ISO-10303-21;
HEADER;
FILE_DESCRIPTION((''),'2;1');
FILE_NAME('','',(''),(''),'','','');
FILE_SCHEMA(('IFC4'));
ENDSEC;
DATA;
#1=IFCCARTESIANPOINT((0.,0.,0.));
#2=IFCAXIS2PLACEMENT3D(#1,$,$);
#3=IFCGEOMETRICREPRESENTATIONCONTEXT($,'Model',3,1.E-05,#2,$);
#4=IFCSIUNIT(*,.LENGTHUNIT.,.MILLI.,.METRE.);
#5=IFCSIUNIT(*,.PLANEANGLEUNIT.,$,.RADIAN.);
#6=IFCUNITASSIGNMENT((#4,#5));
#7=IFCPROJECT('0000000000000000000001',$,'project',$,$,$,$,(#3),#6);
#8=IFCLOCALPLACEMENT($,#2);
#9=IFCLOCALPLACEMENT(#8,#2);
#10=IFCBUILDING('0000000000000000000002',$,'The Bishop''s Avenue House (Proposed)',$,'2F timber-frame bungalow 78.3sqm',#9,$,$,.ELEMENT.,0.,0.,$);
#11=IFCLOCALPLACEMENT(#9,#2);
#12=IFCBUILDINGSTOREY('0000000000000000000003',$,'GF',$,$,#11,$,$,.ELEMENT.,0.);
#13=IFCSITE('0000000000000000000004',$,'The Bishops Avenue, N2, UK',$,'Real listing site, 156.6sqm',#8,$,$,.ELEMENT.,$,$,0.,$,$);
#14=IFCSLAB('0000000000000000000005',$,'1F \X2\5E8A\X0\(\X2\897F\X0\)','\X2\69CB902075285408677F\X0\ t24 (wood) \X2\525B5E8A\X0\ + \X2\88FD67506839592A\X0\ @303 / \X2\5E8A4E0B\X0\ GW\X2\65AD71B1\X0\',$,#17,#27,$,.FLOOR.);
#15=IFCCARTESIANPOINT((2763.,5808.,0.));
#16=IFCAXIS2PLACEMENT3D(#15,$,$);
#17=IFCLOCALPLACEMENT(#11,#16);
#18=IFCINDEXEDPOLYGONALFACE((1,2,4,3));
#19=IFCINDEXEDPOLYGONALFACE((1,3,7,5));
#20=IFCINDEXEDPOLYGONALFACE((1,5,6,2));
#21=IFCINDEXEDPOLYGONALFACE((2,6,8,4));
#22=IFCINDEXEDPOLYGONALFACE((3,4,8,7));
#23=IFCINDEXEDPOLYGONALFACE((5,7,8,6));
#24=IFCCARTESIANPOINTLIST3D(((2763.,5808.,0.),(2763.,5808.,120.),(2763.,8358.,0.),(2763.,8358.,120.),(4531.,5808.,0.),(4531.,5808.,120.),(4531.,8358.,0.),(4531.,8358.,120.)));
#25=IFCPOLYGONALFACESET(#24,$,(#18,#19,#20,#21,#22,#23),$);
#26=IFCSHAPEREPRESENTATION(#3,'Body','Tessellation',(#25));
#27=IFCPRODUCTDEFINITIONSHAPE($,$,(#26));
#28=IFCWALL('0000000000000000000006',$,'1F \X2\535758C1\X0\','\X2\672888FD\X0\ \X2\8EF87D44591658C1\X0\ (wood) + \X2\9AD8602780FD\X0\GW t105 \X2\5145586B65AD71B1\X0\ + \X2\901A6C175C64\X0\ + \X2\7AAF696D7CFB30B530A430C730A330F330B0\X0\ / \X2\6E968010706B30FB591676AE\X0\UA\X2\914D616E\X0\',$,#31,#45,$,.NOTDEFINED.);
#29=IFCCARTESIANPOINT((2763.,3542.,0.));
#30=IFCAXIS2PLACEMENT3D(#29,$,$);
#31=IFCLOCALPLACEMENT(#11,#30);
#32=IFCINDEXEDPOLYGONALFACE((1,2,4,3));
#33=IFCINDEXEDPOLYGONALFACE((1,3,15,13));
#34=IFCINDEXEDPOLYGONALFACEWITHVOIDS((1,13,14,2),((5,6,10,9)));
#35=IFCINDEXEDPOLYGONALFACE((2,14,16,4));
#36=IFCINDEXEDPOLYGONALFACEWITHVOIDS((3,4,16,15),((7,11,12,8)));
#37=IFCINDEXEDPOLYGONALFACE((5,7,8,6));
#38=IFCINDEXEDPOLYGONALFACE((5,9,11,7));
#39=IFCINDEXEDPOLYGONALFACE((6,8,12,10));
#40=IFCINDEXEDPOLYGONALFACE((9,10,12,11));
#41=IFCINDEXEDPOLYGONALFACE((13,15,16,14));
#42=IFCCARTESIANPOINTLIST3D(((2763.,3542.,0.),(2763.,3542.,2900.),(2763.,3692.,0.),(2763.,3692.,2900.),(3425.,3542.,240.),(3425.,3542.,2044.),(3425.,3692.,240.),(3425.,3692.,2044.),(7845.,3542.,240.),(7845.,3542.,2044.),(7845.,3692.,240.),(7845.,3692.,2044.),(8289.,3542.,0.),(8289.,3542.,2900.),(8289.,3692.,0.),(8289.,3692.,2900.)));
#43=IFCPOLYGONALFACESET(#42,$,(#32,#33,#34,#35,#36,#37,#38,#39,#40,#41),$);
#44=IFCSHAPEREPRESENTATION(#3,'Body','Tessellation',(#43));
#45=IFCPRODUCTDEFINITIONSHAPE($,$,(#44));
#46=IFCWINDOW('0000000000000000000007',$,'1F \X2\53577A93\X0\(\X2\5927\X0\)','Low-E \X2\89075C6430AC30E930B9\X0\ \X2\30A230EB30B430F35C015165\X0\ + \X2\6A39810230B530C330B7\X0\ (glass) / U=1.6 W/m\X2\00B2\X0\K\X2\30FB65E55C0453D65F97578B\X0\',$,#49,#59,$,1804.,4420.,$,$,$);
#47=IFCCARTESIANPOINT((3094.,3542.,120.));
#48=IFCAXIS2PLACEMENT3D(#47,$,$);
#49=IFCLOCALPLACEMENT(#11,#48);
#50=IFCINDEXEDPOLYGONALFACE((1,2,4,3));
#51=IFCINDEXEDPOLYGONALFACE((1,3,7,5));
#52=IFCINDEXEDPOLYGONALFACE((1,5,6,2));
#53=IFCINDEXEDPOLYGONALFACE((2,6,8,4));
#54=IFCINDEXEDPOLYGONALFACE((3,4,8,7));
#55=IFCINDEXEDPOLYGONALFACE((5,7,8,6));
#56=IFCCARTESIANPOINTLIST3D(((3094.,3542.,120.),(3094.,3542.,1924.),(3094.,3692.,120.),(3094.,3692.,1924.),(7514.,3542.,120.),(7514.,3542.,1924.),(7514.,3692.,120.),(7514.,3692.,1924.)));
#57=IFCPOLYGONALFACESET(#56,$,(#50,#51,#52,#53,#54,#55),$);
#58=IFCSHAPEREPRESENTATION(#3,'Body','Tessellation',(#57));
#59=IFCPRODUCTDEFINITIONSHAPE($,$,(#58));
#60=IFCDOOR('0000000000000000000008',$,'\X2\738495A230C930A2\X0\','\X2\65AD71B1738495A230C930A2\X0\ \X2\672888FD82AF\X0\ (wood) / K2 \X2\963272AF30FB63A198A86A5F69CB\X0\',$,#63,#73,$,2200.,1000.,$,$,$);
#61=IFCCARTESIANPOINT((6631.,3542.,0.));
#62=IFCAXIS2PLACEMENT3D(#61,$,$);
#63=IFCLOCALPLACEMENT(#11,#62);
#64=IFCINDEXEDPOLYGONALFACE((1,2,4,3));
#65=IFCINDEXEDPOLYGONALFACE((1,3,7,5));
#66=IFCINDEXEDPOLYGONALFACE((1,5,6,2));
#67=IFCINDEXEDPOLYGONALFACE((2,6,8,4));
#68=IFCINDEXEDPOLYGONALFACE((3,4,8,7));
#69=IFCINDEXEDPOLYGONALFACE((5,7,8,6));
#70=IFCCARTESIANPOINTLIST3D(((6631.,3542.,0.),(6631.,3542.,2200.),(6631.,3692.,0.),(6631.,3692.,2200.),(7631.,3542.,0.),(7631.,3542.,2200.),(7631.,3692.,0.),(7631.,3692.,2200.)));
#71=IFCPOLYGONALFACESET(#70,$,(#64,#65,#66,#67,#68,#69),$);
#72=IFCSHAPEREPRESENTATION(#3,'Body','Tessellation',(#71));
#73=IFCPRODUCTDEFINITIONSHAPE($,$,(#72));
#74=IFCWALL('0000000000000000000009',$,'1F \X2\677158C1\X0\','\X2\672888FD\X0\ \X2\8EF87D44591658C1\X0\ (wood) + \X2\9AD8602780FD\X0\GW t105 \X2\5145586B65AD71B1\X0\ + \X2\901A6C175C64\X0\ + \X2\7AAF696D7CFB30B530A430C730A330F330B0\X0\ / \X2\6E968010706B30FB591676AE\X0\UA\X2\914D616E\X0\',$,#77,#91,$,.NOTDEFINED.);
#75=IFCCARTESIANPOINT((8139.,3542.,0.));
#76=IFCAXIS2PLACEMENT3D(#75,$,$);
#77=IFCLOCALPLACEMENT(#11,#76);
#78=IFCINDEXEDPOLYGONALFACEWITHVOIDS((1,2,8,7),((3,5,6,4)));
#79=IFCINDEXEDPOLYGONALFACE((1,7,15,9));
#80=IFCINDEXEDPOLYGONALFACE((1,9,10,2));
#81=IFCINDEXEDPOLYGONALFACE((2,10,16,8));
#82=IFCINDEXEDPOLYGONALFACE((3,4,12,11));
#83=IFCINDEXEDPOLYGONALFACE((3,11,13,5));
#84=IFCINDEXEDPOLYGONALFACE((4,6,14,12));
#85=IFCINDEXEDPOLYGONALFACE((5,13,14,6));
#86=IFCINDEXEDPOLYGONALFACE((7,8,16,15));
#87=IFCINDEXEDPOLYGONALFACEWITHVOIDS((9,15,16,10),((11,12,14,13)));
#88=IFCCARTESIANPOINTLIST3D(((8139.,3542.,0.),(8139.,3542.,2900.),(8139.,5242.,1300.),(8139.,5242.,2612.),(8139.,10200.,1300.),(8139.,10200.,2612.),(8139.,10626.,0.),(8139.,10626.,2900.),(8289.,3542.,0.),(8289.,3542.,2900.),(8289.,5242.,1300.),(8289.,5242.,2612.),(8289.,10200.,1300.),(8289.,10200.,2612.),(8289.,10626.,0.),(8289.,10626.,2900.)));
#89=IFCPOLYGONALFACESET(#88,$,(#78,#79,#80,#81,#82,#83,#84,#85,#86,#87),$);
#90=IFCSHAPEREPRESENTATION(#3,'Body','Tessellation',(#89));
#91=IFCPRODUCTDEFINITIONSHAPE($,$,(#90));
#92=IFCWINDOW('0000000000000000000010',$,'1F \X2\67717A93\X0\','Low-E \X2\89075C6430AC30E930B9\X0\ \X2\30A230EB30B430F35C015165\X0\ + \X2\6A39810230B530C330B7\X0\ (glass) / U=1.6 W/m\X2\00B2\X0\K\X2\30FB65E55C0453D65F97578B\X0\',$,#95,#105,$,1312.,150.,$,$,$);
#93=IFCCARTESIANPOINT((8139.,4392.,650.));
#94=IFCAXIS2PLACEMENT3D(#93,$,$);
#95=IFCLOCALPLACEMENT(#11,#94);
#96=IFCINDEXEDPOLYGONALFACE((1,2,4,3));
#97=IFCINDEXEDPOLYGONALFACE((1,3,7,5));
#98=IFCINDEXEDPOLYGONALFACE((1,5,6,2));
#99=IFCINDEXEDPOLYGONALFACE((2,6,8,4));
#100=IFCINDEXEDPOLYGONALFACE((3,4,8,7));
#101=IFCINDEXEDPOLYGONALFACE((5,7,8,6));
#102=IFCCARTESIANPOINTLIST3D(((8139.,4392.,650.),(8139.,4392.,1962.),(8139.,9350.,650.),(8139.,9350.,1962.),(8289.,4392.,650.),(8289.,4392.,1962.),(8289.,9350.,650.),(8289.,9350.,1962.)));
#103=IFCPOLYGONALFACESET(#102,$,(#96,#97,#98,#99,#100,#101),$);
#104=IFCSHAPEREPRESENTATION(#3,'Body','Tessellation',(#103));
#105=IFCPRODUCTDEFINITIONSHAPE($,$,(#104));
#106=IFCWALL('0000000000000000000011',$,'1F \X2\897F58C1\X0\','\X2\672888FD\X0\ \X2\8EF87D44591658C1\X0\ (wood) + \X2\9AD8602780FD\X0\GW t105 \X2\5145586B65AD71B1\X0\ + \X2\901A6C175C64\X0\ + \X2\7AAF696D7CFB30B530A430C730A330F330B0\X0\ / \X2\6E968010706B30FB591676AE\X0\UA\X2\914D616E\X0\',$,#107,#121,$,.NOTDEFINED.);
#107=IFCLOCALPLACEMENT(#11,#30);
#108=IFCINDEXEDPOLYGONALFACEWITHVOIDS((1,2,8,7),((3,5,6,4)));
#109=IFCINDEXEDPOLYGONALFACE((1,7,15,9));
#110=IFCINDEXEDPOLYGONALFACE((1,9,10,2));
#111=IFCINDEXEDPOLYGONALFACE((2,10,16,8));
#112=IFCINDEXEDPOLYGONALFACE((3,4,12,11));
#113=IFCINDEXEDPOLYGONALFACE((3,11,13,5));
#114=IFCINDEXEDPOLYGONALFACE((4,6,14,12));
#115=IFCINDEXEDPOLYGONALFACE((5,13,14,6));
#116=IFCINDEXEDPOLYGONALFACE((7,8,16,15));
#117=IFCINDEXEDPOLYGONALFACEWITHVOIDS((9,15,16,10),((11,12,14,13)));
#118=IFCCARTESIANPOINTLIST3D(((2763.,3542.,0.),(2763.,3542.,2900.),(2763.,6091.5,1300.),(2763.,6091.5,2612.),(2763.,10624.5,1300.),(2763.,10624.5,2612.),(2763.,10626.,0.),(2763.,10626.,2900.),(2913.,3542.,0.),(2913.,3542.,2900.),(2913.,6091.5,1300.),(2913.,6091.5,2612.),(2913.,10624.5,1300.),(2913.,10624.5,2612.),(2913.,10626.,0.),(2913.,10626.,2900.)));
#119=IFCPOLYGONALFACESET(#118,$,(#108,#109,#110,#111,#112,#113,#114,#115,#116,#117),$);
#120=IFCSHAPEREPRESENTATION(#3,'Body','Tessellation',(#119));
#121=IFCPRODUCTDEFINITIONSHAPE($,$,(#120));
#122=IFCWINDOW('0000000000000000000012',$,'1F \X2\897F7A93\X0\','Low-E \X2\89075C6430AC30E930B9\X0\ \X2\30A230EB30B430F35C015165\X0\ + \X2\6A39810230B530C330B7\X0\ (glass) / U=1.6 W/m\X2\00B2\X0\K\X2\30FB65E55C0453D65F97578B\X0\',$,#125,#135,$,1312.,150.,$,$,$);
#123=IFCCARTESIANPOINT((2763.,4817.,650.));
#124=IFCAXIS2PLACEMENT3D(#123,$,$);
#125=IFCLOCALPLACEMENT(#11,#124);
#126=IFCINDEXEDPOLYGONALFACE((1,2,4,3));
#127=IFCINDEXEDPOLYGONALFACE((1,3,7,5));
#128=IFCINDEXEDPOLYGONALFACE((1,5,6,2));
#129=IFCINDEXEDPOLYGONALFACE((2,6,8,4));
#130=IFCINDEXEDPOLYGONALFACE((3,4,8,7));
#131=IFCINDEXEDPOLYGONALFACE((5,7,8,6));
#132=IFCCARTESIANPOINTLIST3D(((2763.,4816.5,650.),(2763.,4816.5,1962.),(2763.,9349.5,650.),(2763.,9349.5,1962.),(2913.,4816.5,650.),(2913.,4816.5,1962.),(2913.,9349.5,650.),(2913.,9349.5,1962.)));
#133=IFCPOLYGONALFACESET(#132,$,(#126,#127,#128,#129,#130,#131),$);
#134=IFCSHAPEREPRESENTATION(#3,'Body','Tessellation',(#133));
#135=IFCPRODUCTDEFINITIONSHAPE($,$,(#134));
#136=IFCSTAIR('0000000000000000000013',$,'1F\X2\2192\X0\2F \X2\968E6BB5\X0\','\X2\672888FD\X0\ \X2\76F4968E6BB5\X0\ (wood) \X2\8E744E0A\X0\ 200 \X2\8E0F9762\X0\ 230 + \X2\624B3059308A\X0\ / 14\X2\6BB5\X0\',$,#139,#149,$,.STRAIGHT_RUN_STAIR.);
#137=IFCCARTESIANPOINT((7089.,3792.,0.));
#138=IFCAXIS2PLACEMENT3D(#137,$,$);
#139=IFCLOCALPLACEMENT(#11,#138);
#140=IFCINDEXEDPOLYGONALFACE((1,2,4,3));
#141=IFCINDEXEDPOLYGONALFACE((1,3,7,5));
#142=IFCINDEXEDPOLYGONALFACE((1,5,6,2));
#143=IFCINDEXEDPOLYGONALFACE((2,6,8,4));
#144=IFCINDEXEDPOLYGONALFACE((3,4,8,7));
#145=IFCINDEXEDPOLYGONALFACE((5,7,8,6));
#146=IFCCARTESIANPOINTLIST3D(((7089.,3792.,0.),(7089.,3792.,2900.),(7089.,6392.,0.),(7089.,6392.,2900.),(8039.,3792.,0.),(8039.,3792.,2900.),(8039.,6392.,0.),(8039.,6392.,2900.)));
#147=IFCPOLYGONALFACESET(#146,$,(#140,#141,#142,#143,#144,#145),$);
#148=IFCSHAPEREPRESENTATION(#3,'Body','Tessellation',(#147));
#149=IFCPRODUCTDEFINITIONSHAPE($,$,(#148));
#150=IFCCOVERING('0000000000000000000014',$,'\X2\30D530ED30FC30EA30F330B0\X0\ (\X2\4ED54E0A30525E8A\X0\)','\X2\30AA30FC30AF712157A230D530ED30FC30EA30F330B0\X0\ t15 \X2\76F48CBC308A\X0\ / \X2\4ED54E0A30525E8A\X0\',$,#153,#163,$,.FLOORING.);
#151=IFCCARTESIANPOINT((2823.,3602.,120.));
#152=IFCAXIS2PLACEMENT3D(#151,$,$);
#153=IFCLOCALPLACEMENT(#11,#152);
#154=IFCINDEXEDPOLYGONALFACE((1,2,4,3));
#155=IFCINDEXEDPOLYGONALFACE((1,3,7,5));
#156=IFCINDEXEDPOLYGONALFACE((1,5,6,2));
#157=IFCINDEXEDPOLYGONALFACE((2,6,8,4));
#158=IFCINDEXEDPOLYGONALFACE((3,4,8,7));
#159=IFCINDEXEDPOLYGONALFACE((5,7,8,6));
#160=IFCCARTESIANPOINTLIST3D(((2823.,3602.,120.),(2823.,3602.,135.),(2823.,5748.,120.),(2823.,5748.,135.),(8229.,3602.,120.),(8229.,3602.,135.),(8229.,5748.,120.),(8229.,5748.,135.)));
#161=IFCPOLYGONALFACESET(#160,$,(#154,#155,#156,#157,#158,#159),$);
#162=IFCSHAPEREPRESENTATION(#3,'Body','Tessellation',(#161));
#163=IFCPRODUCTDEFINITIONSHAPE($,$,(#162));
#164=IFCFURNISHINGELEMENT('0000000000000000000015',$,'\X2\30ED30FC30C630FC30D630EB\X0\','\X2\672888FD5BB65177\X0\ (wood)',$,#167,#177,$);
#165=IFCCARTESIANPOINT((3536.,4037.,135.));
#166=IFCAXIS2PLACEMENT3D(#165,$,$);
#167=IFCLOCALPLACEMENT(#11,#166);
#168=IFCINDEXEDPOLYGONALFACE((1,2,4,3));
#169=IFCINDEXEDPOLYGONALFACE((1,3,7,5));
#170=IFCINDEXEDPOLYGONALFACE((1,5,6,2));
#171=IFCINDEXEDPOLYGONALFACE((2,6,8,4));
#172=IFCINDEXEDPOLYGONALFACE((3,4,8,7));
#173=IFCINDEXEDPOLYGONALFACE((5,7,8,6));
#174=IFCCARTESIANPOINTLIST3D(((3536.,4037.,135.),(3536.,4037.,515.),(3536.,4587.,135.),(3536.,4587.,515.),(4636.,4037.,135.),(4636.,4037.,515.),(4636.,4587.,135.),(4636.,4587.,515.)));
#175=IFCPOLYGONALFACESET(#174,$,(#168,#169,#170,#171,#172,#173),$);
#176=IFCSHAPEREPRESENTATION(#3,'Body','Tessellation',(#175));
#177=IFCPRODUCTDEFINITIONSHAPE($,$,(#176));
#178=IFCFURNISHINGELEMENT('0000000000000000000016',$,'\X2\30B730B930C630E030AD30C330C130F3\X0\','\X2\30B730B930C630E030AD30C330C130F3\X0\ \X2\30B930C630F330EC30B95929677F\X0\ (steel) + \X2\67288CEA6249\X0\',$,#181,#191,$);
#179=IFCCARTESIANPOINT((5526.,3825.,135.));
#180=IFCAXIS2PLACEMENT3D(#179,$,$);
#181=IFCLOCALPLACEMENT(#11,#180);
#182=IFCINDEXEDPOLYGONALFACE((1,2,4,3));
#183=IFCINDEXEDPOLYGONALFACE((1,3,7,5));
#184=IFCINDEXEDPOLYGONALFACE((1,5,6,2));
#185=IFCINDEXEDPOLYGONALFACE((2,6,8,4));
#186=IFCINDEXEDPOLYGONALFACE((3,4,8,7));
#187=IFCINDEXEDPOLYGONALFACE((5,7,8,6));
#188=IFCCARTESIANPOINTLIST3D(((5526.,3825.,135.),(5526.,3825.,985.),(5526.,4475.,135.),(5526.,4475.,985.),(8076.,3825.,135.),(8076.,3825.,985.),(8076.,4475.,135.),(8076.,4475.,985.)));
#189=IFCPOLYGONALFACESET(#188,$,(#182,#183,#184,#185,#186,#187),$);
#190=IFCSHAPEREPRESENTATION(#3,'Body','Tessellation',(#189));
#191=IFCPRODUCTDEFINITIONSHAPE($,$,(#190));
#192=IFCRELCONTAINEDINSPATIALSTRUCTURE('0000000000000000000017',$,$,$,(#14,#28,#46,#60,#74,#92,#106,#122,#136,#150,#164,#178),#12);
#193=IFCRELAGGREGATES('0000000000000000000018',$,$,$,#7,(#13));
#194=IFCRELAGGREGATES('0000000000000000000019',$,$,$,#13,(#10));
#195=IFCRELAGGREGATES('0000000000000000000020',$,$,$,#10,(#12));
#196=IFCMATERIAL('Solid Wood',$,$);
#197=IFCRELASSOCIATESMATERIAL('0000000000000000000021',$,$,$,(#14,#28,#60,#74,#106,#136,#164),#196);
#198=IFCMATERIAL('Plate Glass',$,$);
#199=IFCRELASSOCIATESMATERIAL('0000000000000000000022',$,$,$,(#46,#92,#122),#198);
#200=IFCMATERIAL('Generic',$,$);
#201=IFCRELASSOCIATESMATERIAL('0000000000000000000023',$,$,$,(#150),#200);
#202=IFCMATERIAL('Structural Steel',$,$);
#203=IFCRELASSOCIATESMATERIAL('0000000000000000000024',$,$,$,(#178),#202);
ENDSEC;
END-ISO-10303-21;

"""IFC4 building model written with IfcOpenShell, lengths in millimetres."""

from ifc_helpers import new_model, si_unit, frame, frame_2d, origin, place, context, project, spatial, rectangle, extrude, material, element, fill, save


model = new_model("IFC4")

# Units and contexts
model_context = context("Model", 3, precision=1e-05, world=origin())
ifc_project = project(units=[si_unit("LENGTHUNIT", "METRE", prefix="MILLI"), si_unit("PLANEANGLEUNIT", "RADIAN")], contexts=[model_context])

# Site, building, storey
site_placement = place(None, origin())
site = spatial("IfcSite", under=ifc_project, at=site_placement, Name="The Bishops Avenue, N2, UK", ObjectType="Real listing site, 156.6sqm", CompositionType="ELEMENT", RefElevation=0.0)
building_placement = place(site_placement, origin())
building = spatial("IfcBuilding", under=site, at=building_placement, Name="The Bishop's Avenue House (Proposed)", ObjectType="2F timber-frame bungalow 78.3sqm", CompositionType="ELEMENT", ElevationOfRefHeight=0.0, ElevationOfTerrain=0.0)
storey_placement = place(building_placement, origin())
storey = spatial("IfcBuildingStorey", under=building, at=storey_placement, Name="GF", CompositionType="ELEMENT", Elevation=0.0)

# Slab
ifc_material_1 = material(Name="Solid Wood")
slab_1_placement = place(storey_placement, frame((2763.0, 5808.0, 0.0)))
element("IfcSlab", 1, at=slab_1_placement, inside=storey, material=ifc_material_1, Name="1F 床(西)", Description="構造用合板 t24 (wood) 剛床 + 製材根太 @303 / 床下 GW断熱", PredefinedType="FLOOR", context=model_context, shape_type="SweptSolid", body=[
    extrude(rectangle(XDim=1768.0, YDim=2550.0, at=frame_2d((884.0, 1275.0))), frame((2763.0, 5808.0, 0.0)), (0.0, 0.0, 1.0), 120.0),
])

# Wall, openings, window, door
wall_1_placement = place(storey_placement, frame((2763.0, 3542.0, 0.0)))
wall_1 = element("IfcWall", 2, at=wall_1_placement, inside=storey, material=ifc_material_1, Name="1F 南壁", Description="木製 軸組外壁 (wood) + 高性能GW t105 充填断熱 + 通気層 + 窯業系サイディング / 準耐火・外皮UA配慮", PredefinedType="NOTDEFINED", context=model_context, shape_type="SweptSolid", body=[
    extrude(rectangle(XDim=5526.0, YDim=150.0, at=frame_2d((2763.0, 75.0))), frame((2763.0, 3542.0, 0.0)), (0.0, 0.0, 1.0), 2900.0),
])
opening_1_placement = place(storey_placement, frame((3094.0, 3542.0, 120.0)))
opening_1 = element("IfcOpeningElement", 3, at=opening_1_placement, cuts=wall_1, PredefinedType="NOTDEFINED", context=model_context, shape_type="SweptSolid", body=[
    extrude(rectangle(XDim=4420.0, YDim=150.0, at=frame_2d((2210.0, 75.0))), frame((3094.0, 3542.0, 120.0)), (0.0, 0.0, 1.0), 1804.0),
])
opening_2_placement = place(storey_placement, frame((6631.0, 3542.0, 0.0)))
opening_2 = element("IfcOpeningElement", 4, at=opening_2_placement, cuts=wall_1, PredefinedType="NOTDEFINED", context=model_context, shape_type="SweptSolid", body=[
    extrude(rectangle(XDim=1000.0, YDim=150.0, at=frame_2d((500.0, 75.0))), frame((6631.0, 3542.0, 0.0)), (0.0, 0.0, 1.0), 2200.0),
])
ifc_material_2 = material(Name="Plate Glass")
window_1_placement = place(storey_placement, frame((3094.0, 3542.0, 120.0)))
window_1 = element("IfcWindow", 5, at=window_1_placement, inside=storey, material=ifc_material_2, Name="1F 南窓(大)", Description="Low-E 複層ガラス アルゴン封入 + 樹脂サッシ (glass) / U=1.6 W/m²K・日射取得型", OverallHeight=1804.0, OverallWidth=4420.0, context=model_context, shape_type="SweptSolid", body=[
    extrude(rectangle(XDim=4420.0, YDim=150.0, at=frame_2d((2210.0, 75.0))), frame((3094.0, 3542.0, 120.0)), (0.0, 0.0, 1.0), 1804.0),
])
fill(opening_1, window_1)
door_placement = place(storey_placement, frame((6631.0, 3542.0, 0.0)))
door = element("IfcDoor", 6, at=door_placement, inside=storey, material=ifc_material_1, Name="玄関ドア", Description="断熱玄関ドア 木製芯 (wood) / K2 防犯・採風機構", OverallHeight=2200.0, OverallWidth=1000.0, context=model_context, shape_type="SweptSolid", body=[
    extrude(rectangle(XDim=1000.0, YDim=150.0, at=frame_2d((500.0, 75.0))), frame((6631.0, 3542.0, 0.0)), (0.0, 0.0, 1.0), 2200.0),
])
fill(opening_2, door)

# Walls, openings, windows
wall_2_placement = place(storey_placement, frame((8139.0, 3542.0, 0.0)))
wall_2 = element("IfcWall", 7, at=wall_2_placement, inside=storey, material=ifc_material_1, Name="1F 東壁", Description="木製 軸組外壁 (wood) + 高性能GW t105 充填断熱 + 通気層 + 窯業系サイディング / 準耐火・外皮UA配慮", PredefinedType="NOTDEFINED", context=model_context, shape_type="SweptSolid", body=[
    extrude(rectangle(XDim=150.0, YDim=7084.0, at=frame_2d((75.0, 3542.0))), frame((8139.0, 3542.0, 0.0)), (0.0, 0.0, 1.0), 2900.0),
])
opening_3_placement = place(storey_placement, frame((8139.0, 4392.0, 650.0)))
opening_3 = element("IfcOpeningElement", 8, at=opening_3_placement, cuts=wall_2, PredefinedType="NOTDEFINED", context=model_context, shape_type="SweptSolid", body=[
    extrude(rectangle(XDim=150.0, YDim=4958.0, at=frame_2d((75.0, 2479.0))), frame((8139.0, 4392.0, 650.0)), (0.0, 0.0, 1.0), 1312.0),
])
window_2_placement = place(storey_placement, frame((8139.0, 4392.0, 650.0)))
window_2 = element("IfcWindow", 9, at=window_2_placement, inside=storey, material=ifc_material_2, Name="1F 東窓", Description="Low-E 複層ガラス アルゴン封入 + 樹脂サッシ (glass) / U=1.6 W/m²K・日射取得型", OverallHeight=1312.0, OverallWidth=150.0, context=model_context, shape_type="SweptSolid", body=[
    extrude(rectangle(XDim=150.0, YDim=4958.0, at=frame_2d((75.0, 2479.0))), frame((8139.0, 4392.0, 650.0)), (0.0, 0.0, 1.0), 1312.0),
])
fill(opening_3, window_2)
wall_3_placement = place(storey_placement, frame((2763.0, 3542.0, 0.0)))
wall_3 = element("IfcWall", 10, at=wall_3_placement, inside=storey, material=ifc_material_1, Name="1F 西壁", Description="木製 軸組外壁 (wood) + 高性能GW t105 充填断熱 + 通気層 + 窯業系サイディング / 準耐火・外皮UA配慮", PredefinedType="NOTDEFINED", context=model_context, shape_type="SweptSolid", body=[
    extrude(rectangle(XDim=150.0, YDim=7084.0, at=frame_2d((75.0, 3542.0))), frame((2763.0, 3542.0, 0.0)), (0.0, 0.0, 1.0), 2900.0),
])
opening_4_placement = place(storey_placement, frame((2763.0, 4817.0, 650.0)))
opening_4 = element("IfcOpeningElement", 11, at=opening_4_placement, cuts=wall_3, PredefinedType="NOTDEFINED", context=model_context, shape_type="SweptSolid", body=[
    extrude(rectangle(XDim=150.0, YDim=4533.0, at=frame_2d((75.0, 2266.0))), frame((2763.0, 4817.0, 650.0)), (0.0, 0.0, 1.0), 1312.0),
])
window_3_placement = place(storey_placement, frame((2763.0, 4817.0, 650.0)))
window_3 = element("IfcWindow", 12, at=window_3_placement, inside=storey, material=ifc_material_2, Name="1F 西窓", Description="Low-E 複層ガラス アルゴン封入 + 樹脂サッシ (glass) / U=1.6 W/m²K・日射取得型", OverallHeight=1312.0, OverallWidth=150.0, context=model_context, shape_type="SweptSolid", body=[
    extrude(rectangle(XDim=150.0, YDim=4533.0, at=frame_2d((75.0, 2266.0))), frame((2763.0, 4817.0, 650.0)), (0.0, 0.0, 1.0), 1312.0),
])
fill(opening_4, window_3)

# Stair
stair_placement = place(storey_placement, frame((7089.0, 3792.0, 0.0)))
element("IfcStair", 13, at=stair_placement, inside=storey, material=ifc_material_1, Name="1F→2F 階段", Description="木製 直階段 (wood) 蹴上 200 踏面 230 + 手すり / 14段", PredefinedType="STRAIGHT_RUN_STAIR", context=model_context, shape_type="SweptSolid", body=[
    extrude(rectangle(XDim=950.0, YDim=2600.0, at=frame_2d((475.0, 1300.0))), frame((7089.0, 3792.0, 0.0)), (0.0, 0.0, 1.0), 2900.0),
])

# Covering
ifc_material_3 = material(Name="Generic")
covering_placement = place(storey_placement, frame((2823.0, 3602.0, 120.0)))
element("IfcCovering", 14, at=covering_placement, inside=storey, material=ifc_material_3, Name="フローリング (仕上げ床)", Description="オーク無垢フローリング t15 直貼り / 仕上げ床", PredefinedType="FLOORING", context=model_context, shape_type="SweptSolid", body=[
    extrude(rectangle(XDim=5406.0, YDim=2146.0, at=frame_2d((2703.0, 1073.0))), frame((2823.0, 3602.0, 120.0)), (0.0, 0.0, 1.0), 15.0),
])

# Furnishing elements
furnishing_1_placement = place(storey_placement, frame((3536.0, 4037.0, 135.0)))
element("IfcFurnishingElement", 15, at=furnishing_1_placement, inside=storey, material=ifc_material_1, Name="ローテーブル", Description="木製家具 (wood)", context=model_context, shape_type="SweptSolid", body=[
    extrude(rectangle(XDim=1100.0, YDim=550.0, at=frame_2d((550.0, 275.0))), frame((3536.0, 4037.0, 135.0)), (0.0, 0.0, 1.0), 380.0),
])
ifc_material_4 = material(Name="Structural Steel")
furnishing_2_placement = place(storey_placement, frame((5526.0, 3825.0, 135.0)))
element("IfcFurnishingElement", 16, at=furnishing_2_placement, inside=storey, material=ifc_material_4, Name="システムキッチン", Description="システムキッチン ステンレス天板 (steel) + 木質扉", context=model_context, shape_type="SweptSolid", body=[
    extrude(rectangle(XDim=2550.0, YDim=650.0, at=frame_2d((1275.0, 325.0))), frame((5526.0, 3825.0, 135.0)), (0.0, 0.0, 1.0), 850.0),
])

save(model, "model.ifc")
